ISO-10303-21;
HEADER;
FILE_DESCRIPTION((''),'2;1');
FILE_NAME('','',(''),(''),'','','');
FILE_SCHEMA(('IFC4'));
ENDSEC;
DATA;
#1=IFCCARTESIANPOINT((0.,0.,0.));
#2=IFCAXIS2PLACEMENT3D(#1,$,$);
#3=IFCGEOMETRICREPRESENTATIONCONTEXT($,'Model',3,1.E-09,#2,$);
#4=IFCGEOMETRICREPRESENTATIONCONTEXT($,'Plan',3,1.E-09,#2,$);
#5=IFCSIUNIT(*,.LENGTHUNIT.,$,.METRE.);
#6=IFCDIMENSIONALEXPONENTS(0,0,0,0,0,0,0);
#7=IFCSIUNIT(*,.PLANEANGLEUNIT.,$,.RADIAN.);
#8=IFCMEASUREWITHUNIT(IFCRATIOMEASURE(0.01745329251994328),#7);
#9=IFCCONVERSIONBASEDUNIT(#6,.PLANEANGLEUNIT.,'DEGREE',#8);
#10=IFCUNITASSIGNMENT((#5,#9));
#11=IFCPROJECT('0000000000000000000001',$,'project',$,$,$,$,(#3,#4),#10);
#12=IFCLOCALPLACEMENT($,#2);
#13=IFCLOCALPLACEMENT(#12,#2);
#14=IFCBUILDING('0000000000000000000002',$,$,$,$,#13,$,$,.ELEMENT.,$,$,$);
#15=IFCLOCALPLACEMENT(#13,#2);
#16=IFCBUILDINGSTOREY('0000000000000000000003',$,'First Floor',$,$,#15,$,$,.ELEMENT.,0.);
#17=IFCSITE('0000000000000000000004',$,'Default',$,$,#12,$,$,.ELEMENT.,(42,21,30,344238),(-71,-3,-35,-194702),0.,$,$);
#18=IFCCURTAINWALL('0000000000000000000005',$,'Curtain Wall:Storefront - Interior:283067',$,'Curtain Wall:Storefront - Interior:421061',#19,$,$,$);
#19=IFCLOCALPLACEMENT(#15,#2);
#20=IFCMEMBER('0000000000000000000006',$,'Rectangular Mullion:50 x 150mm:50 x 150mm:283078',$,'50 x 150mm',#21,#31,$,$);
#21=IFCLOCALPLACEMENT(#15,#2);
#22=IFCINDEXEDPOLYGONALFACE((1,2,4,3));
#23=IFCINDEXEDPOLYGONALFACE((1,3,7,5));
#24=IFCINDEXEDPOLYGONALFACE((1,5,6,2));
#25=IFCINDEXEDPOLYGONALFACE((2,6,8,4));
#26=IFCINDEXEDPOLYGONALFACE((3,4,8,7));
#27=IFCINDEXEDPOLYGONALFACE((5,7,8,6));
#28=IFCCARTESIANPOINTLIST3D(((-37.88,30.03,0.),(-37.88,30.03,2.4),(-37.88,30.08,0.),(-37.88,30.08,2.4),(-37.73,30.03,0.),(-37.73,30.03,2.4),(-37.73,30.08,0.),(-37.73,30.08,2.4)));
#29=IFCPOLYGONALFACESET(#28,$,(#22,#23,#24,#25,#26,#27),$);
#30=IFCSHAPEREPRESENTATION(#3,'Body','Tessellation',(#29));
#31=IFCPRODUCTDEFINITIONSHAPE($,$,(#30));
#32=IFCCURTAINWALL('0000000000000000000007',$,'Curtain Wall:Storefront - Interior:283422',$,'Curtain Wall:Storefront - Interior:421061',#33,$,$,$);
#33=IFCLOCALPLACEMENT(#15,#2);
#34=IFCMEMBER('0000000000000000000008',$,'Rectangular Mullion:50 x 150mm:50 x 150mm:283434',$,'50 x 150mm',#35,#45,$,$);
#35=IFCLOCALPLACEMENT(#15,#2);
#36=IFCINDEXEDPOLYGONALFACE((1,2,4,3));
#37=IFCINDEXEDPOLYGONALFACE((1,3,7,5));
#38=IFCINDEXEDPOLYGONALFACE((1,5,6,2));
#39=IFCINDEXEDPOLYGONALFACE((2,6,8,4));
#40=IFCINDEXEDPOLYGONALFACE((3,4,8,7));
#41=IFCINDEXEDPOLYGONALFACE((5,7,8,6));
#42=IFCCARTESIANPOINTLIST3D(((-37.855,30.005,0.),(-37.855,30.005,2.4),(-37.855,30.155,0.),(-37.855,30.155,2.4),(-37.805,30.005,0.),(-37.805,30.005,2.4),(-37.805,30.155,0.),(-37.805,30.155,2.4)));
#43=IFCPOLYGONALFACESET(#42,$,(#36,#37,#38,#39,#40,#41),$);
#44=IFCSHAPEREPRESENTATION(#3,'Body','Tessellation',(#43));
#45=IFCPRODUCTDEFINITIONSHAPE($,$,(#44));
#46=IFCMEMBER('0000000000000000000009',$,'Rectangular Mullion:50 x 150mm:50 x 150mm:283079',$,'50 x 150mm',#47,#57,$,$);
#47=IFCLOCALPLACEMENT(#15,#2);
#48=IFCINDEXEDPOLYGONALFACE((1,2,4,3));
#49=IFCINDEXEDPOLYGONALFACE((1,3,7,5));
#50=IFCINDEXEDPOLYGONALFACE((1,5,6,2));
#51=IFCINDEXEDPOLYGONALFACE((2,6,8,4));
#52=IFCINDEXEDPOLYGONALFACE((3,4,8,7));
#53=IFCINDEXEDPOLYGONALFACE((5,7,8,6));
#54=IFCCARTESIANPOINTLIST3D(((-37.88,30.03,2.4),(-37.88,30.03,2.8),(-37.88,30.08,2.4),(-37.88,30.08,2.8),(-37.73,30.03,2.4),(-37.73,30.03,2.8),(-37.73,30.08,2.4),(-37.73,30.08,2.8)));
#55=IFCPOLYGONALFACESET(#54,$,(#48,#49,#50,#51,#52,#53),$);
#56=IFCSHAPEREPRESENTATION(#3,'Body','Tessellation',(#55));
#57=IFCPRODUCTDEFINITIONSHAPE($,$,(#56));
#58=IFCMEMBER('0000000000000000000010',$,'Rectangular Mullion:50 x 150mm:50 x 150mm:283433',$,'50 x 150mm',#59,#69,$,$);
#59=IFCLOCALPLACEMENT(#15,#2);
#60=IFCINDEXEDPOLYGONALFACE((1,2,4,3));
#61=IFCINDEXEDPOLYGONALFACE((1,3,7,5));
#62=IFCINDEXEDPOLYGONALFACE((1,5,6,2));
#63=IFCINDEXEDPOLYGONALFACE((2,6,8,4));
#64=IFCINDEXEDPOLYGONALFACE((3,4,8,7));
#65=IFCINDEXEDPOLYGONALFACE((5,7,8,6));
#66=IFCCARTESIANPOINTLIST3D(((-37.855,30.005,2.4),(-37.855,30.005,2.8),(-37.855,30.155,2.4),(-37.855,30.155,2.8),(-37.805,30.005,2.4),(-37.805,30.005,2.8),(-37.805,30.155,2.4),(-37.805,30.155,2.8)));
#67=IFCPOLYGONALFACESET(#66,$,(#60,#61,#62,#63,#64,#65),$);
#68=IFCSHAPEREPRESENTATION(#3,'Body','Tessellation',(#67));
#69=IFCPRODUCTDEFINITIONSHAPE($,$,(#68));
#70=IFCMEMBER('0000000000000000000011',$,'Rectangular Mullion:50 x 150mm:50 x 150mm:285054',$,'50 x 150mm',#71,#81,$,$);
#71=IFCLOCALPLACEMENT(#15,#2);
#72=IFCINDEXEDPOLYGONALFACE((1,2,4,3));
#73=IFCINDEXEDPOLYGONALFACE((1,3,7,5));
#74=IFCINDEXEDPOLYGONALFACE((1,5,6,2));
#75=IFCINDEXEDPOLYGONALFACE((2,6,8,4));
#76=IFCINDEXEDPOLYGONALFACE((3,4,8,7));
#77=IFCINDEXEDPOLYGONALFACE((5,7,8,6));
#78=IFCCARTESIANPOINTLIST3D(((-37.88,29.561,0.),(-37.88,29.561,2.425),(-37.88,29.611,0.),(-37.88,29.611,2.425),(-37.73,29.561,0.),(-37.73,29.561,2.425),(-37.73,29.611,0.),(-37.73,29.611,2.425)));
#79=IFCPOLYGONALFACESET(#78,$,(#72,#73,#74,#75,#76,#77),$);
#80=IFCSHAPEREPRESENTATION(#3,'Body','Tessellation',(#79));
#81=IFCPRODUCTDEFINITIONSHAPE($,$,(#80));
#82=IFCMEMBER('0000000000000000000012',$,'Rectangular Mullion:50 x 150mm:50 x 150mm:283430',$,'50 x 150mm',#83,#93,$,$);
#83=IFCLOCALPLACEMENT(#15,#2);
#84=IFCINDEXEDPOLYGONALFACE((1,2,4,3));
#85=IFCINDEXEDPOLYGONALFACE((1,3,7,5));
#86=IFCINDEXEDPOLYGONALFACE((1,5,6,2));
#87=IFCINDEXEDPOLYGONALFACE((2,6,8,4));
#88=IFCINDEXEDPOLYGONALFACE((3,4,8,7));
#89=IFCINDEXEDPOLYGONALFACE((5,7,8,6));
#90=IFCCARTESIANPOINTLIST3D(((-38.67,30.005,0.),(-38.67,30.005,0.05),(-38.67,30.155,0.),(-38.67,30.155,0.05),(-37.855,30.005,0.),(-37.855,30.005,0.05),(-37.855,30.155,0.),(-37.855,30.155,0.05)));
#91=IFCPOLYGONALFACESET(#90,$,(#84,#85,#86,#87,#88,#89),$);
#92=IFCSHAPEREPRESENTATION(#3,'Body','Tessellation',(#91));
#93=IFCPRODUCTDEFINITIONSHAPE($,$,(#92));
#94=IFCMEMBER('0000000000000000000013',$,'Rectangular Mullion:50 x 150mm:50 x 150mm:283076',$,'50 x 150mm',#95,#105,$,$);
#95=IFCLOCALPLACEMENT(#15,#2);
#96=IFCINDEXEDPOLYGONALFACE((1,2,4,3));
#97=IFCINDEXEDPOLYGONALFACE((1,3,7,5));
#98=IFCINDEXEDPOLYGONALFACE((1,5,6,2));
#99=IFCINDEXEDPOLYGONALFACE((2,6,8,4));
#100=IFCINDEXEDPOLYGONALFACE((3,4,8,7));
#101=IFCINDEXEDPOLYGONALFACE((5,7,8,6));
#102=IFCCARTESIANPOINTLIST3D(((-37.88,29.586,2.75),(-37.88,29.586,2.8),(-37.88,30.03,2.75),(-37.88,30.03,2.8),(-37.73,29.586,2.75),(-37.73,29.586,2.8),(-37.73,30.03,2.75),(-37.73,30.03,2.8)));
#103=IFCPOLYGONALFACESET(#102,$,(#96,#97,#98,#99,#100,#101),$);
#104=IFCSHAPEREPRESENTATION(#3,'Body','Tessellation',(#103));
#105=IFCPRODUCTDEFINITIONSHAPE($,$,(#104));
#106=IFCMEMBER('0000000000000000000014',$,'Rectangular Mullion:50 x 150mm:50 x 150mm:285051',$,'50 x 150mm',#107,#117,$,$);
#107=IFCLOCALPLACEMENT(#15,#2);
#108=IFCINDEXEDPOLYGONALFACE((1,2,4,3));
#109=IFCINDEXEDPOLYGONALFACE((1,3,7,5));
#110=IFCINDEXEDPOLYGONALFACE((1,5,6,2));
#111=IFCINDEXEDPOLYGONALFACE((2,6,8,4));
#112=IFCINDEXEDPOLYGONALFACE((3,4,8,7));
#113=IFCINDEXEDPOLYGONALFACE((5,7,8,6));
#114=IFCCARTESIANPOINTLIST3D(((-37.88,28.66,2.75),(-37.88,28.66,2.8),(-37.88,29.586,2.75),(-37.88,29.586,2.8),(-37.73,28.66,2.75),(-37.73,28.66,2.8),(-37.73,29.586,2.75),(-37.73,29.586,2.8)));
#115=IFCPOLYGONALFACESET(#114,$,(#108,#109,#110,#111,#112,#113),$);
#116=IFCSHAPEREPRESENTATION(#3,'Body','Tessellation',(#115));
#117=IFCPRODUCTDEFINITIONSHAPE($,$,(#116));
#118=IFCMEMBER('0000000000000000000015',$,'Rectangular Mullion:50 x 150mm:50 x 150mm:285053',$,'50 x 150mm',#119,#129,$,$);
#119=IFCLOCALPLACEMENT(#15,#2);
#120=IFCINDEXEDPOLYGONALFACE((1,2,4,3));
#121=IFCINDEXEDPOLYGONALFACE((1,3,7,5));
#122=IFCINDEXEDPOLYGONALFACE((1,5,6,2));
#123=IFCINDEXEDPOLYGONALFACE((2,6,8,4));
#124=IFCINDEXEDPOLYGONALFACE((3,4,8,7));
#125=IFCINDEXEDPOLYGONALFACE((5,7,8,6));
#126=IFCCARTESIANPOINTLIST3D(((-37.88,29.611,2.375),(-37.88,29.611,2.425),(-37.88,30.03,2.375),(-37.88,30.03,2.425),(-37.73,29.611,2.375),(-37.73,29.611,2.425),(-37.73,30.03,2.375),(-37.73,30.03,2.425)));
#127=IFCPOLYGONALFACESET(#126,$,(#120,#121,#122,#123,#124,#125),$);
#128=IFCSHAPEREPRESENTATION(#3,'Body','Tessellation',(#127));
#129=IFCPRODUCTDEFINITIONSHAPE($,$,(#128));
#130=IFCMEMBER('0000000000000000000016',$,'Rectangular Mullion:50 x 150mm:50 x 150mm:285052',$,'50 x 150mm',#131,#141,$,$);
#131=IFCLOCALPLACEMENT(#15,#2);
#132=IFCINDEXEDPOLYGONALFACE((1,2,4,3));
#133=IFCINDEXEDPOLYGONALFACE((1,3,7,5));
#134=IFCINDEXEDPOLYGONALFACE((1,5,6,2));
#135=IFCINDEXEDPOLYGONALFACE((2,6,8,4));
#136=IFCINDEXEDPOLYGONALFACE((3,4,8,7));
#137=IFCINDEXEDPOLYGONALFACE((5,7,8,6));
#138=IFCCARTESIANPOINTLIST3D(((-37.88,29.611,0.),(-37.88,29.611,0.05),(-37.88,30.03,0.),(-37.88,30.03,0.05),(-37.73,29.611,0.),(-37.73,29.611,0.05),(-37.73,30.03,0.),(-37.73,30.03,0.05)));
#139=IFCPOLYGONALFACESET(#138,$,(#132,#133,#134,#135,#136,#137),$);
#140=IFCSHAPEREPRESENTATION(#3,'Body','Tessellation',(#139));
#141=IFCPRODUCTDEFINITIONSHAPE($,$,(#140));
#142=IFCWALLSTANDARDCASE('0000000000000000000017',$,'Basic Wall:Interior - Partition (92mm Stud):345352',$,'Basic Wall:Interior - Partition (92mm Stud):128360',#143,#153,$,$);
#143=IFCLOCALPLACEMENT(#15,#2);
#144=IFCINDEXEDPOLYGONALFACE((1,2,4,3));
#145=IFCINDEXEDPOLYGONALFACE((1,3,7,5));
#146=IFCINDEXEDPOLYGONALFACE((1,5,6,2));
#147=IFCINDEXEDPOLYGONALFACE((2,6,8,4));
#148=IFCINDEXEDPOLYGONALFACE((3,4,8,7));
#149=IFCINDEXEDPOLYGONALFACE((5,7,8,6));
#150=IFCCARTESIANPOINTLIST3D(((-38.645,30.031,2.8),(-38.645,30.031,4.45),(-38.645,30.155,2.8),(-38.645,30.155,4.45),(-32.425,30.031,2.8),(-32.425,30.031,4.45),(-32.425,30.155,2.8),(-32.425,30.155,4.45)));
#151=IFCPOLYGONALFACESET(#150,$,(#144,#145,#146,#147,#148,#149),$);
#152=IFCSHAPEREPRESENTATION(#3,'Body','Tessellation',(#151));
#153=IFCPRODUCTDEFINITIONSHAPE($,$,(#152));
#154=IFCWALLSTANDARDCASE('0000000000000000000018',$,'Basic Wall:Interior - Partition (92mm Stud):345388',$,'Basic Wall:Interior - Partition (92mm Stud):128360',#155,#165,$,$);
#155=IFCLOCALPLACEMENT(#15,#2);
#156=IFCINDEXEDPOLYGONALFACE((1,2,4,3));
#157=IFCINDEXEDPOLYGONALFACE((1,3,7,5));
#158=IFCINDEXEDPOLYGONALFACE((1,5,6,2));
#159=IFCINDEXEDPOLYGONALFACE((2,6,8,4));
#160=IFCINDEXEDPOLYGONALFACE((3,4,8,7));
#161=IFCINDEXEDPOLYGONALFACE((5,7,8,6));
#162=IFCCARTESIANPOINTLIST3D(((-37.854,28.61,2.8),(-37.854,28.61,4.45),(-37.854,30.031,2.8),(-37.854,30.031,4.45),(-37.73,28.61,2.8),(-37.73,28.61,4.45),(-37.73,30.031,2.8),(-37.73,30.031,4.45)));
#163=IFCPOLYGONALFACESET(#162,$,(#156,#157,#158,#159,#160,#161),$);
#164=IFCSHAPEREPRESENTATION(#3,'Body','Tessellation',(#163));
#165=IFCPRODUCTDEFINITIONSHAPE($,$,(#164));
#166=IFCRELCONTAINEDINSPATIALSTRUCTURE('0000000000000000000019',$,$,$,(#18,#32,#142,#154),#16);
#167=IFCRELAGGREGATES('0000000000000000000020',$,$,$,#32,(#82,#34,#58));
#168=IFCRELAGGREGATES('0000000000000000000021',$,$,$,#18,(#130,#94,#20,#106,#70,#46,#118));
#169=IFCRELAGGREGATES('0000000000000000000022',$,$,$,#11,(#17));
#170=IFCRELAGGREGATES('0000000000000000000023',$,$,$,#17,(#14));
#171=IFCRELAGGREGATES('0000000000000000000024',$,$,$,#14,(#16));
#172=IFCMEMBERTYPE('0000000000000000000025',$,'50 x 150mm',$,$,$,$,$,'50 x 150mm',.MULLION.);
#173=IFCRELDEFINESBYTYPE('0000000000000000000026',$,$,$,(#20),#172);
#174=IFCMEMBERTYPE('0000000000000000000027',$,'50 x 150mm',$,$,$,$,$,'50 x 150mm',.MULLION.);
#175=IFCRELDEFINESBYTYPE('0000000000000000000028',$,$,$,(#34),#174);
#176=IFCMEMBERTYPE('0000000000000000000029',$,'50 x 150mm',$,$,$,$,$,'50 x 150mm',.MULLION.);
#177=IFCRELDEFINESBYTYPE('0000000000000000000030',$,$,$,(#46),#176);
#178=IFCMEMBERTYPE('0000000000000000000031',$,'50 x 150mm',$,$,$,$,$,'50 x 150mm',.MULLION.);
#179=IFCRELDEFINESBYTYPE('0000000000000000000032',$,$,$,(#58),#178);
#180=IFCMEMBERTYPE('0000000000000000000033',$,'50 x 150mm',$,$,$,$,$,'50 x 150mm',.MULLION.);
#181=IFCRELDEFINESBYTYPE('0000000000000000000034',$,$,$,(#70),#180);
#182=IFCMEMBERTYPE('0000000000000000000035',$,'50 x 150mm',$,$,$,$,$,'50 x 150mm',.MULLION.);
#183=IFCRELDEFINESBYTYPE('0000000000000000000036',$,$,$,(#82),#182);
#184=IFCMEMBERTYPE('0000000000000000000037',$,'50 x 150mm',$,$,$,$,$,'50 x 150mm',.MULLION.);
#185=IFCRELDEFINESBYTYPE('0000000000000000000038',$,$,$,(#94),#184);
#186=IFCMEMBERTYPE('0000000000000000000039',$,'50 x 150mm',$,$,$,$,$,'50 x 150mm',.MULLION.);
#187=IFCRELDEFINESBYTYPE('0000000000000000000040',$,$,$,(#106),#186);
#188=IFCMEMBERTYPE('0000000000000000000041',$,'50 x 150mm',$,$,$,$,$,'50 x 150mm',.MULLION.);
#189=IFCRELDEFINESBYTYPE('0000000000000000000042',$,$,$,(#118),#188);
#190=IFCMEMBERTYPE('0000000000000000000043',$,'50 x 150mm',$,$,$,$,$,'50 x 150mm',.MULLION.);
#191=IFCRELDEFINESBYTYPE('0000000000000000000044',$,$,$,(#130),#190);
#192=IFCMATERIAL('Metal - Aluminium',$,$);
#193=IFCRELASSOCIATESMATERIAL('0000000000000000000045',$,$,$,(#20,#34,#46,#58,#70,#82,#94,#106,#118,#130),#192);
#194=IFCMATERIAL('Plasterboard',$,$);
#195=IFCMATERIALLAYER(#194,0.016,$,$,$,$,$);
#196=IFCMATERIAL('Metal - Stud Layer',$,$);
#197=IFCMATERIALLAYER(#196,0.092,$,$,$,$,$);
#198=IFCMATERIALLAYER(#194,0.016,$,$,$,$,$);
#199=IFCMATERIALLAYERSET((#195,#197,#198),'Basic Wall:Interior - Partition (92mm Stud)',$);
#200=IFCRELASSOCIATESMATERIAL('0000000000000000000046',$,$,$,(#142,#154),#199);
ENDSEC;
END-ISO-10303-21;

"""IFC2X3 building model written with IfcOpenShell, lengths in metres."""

from ifc_helpers import new_model, entity, si_unit, converted_unit, frame, frame_2d, origin, origin_2d_with_axis, place, context, project, spatial, rectangle, extrude, source, transform, mapped, material, layer, layer_set, layer_usage, type_object, type_shapes, element, aggregate, save


model = new_model("IFC2X3")

# Units and contexts
model_context = context("Model", 3, precision=1e-09, world=origin())
plan_context = context("Plan", 3, precision=1e-09, world=origin())
ifc_project = project(units=[si_unit("LENGTHUNIT", "METRE"), converted_unit("PLANEANGLEUNIT", "DEGREE", entity("IfcRatioMeasure", 0.01745329251994328), si_unit("PLANEANGLEUNIT", "RADIAN"), dimensions=[0, 0, 0, 0, 0, 0, 0])], contexts=[model_context, plan_context])

# Site, building, storey
site_placement = place(None, origin())
site = spatial("IfcSite", under=ifc_project, at=site_placement, Name="Default", CompositionType="ELEMENT", RefLatitude=(42, 21, 30, 344238), RefLongitude=(-71, -3, -35, -194702), RefElevation=0.0)
building_placement = place(site_placement, origin())
building = spatial("IfcBuilding", under=site, at=building_placement, CompositionType="ELEMENT")
storey_placement = place(building_placement, origin())
storey = spatial("IfcBuildingStorey", under=building, at=storey_placement, Name="First Floor", CompositionType="ELEMENT", Elevation=0.0)

# Curtain walls, members
curtain_wall_1_placement = place(storey_placement, origin())
curtain_wall_1 = element("IfcCurtainWall", 1, at=curtain_wall_1_placement, inside=storey, Name="Curtain Wall:Storefront - Interior:283067", ObjectType="Curtain Wall:Storefront - Interior:421061")
ifc_material_1 = material(Name="Metal - Aluminium")
member_type_1 = type_object("IfcMemberType", Name="50 x 150mm", ElementType="50 x 150mm", PredefinedType="MULLION")
shared_shape_1 = source(origin(), model_context, "Body", "SweptSolid", [
    extrude(rectangle(XDim=0.05, YDim=0.15, at=origin_2d_with_axis()), frame((-0.025, 0.0, -2.4), z_axis=(0.0, 0.0, 1.0), x_axis=(-1.0, 0.0, 0.0)), (0.0, 0.0, 1.0), 2.4),
])
type_shapes(member_type_1, [shared_shape_1])
member_1_placement = place(storey_placement, frame((-37.805, 30.08, 0.0), z_axis=(0.0, 0.0, -1.0), x_axis=(0.0, 1.0, 0.0)))
member_1 = element("IfcMember", 2, at=member_1_placement, type_object=member_type_1, material=ifc_material_1, Name="Rectangular Mullion:50 x 150mm:50 x 150mm:283078", ObjectType="50 x 150mm", context=model_context, shape_type="MappedRepresentation", body=[
    mapped(shared_shape_1, transform((0.0, 0.0, 0.0), scale=1.0)),
])
curtain_wall_2_placement = place(storey_placement, origin())
curtain_wall_2 = element("IfcCurtainWall", 3, at=curtain_wall_2_placement, inside=storey, Name="Curtain Wall:Storefront - Interior:283422", ObjectType="Curtain Wall:Storefront - Interior:421061")
member_type_2 = type_object("IfcMemberType", Name="50 x 150mm", ElementType="50 x 150mm", PredefinedType="MULLION")
type_shapes(member_type_2, [shared_shape_1])
member_2_placement = place(storey_placement, frame((-37.805, 30.08, 2.4)))
member_2 = element("IfcMember", 4, at=member_2_placement, type_object=member_type_2, material=ifc_material_1, Name="Rectangular Mullion:50 x 150mm:50 x 150mm:283434", ObjectType="50 x 150mm", context=model_context, shape_type="MappedRepresentation", body=[
    mapped(shared_shape_1, transform((0.0, 0.0, 0.0), scale=1.0)),
])

# Members
member_type_3 = type_object("IfcMemberType", Name="50 x 150mm", ElementType="50 x 150mm", PredefinedType="MULLION")
shared_shape_2 = source(origin(), model_context, "Body", "SweptSolid", [
    extrude(rectangle(XDim=0.05, YDim=0.15, at=origin_2d_with_axis()), frame((-0.025, 0.0, -0.4), z_axis=(0.0, 0.0, 1.0), x_axis=(-1.0, 0.0, 0.0)), (0.0, 0.0, 1.0), 0.4),
])
type_shapes(member_type_3, [shared_shape_2])
member_3_placement = place(storey_placement, frame((-37.805, 30.08, 2.4), z_axis=(0.0, 0.0, -1.0), x_axis=(0.0, 1.0, 0.0)))
member_3 = element("IfcMember", 5, at=member_3_placement, type_object=member_type_3, material=ifc_material_1, Name="Rectangular Mullion:50 x 150mm:50 x 150mm:283079", ObjectType="50 x 150mm", context=model_context, shape_type="MappedRepresentation", body=[
    mapped(shared_shape_2, transform((0.0, 0.0, 0.0), scale=1.0)),
])
member_type_4 = type_object("IfcMemberType", Name="50 x 150mm", ElementType="50 x 150mm", PredefinedType="MULLION")
type_shapes(member_type_4, [shared_shape_2])
member_4_placement = place(storey_placement, frame((-37.805, 30.08, 2.8)))
member_4 = element("IfcMember", 6, at=member_4_placement, type_object=member_type_4, material=ifc_material_1, Name="Rectangular Mullion:50 x 150mm:50 x 150mm:283433", ObjectType="50 x 150mm", context=model_context, shape_type="MappedRepresentation", body=[
    mapped(shared_shape_2, transform((0.0, 0.0, 0.0), scale=1.0)),
])
member_type_5 = type_object("IfcMemberType", Name="50 x 150mm", ElementType="50 x 150mm", PredefinedType="MULLION")
shared_shape_3 = source(origin(), model_context, "Body", "SweptSolid", [
    extrude(rectangle(XDim=0.05, YDim=0.15, at=origin_2d_with_axis()), frame((0.0, 0.0, -2.425), z_axis=(0.0, 0.0, 1.0), x_axis=(-1.0, 0.0, 0.0)), (0.0, 0.0, 1.0), 2.425),
])
type_shapes(member_type_5, [shared_shape_3])
member_5_placement = place(storey_placement, frame((-37.805, 29.586, 0.0), z_axis=(0.0, 0.0, -1.0), x_axis=(0.0, 1.0, 0.0)))
member_5 = element("IfcMember", 7, at=member_5_placement, type_object=member_type_5, material=ifc_material_1, Name="Rectangular Mullion:50 x 150mm:50 x 150mm:285054", ObjectType="50 x 150mm", context=model_context, shape_type="MappedRepresentation", body=[
    mapped(shared_shape_3, transform((0.0, 0.0, 0.0), scale=1.0)),
])
member_type_6 = type_object("IfcMemberType", Name="50 x 150mm", ElementType="50 x 150mm", PredefinedType="MULLION")
shared_shape_4 = source(origin(), model_context, "Body", "SweptSolid", [
    extrude(rectangle(XDim=0.05, YDim=0.15, at=origin_2d_with_axis()), frame((-0.025, 0.0, -0.815), z_axis=(0.0, 0.0, 1.0), x_axis=(-1.0, 0.0, 0.0)), (0.0, 0.0, 1.0), 0.815),
])
type_shapes(member_type_6, [shared_shape_4])
member_6_placement = place(storey_placement, frame((-37.855, 30.08, 0.0), z_axis=(1.0, 0.0, 0.0), x_axis=(0.0, 0.0, -1.0)))
member_6 = element("IfcMember", 8, at=member_6_placement, type_object=member_type_6, material=ifc_material_1, Name="Rectangular Mullion:50 x 150mm:50 x 150mm:283430", ObjectType="50 x 150mm", context=model_context, shape_type="MappedRepresentation", body=[
    mapped(shared_shape_4, transform((0.0, 0.0, 0.0), scale=1.0)),
])
member_type_7 = type_object("IfcMemberType", Name="50 x 150mm", ElementType="50 x 150mm", PredefinedType="MULLION")
shared_shape_5 = source(origin(), model_context, "Body", "SweptSolid", [
    extrude(rectangle(XDim=0.05, YDim=0.15, at=origin_2d_with_axis()), frame((-0.025, 0.0, -0.444), z_axis=(0.0, 0.0, 1.0), x_axis=(-1.0, 0.0, 0.0)), (0.0, 0.0, 1.0), 0.444),
])
type_shapes(member_type_7, [shared_shape_5])
member_7_placement = place(storey_placement, frame((-37.805, 30.03, 2.8), z_axis=(0.0, 1.0, 0.0), x_axis=(0.0, 0.0, 1.0)))
member_7 = element("IfcMember", 9, at=member_7_placement, type_object=member_type_7, material=ifc_material_1, Name="Rectangular Mullion:50 x 150mm:50 x 150mm:283076", ObjectType="50 x 150mm", context=model_context, shape_type="MappedRepresentation", body=[
    mapped(shared_shape_5, transform((0.0, 0.0, 0.0), scale=1.0)),
])
member_type_8 = type_object("IfcMemberType", Name="50 x 150mm", ElementType="50 x 150mm", PredefinedType="MULLION")
shared_shape_6 = source(origin(), model_context, "Body", "SweptSolid", [
    extrude(rectangle(XDim=0.05, YDim=0.15, at=origin_2d_with_axis()), frame((-0.025, 0.0, -0.926), z_axis=(0.0, 0.0, 1.0), x_axis=(-1.0, 0.0, 0.0)), (0.0, 0.0, 1.0), 0.926),
])
type_shapes(member_type_8, [shared_shape_6])
member_8_placement = place(storey_placement, frame((-37.805, 29.586, 2.8), z_axis=(0.0, 1.0, 0.0), x_axis=(0.0, 0.0, 1.0)))
member_8 = element("IfcMember", 10, at=member_8_placement, type_object=member_type_8, material=ifc_material_1, Name="Rectangular Mullion:50 x 150mm:50 x 150mm:285051", ObjectType="50 x 150mm", context=model_context, shape_type="MappedRepresentation", body=[
    mapped(shared_shape_6, transform((0.0, 0.0, 0.0), scale=1.0)),
])
member_type_9 = type_object("IfcMemberType", Name="50 x 150mm", ElementType="50 x 150mm", PredefinedType="MULLION")
shared_shape_7 = source(origin(), model_context, "Body", "SweptSolid", [
    extrude(rectangle(XDim=0.05, YDim=0.15, at=origin_2d_with_axis()), frame((0.0, 0.0, -0.419), z_axis=(0.0, 0.0, 1.0), x_axis=(-1.0, 0.0, 0.0)), (0.0, 0.0, 1.0), 0.419),
])
type_shapes(member_type_9, [shared_shape_7])
member_9_placement = place(storey_placement, frame((-37.805, 30.03, 2.4), z_axis=(0.0, 1.0, 0.0), x_axis=(0.0, 0.0, 1.0)))
member_9 = element("IfcMember", 11, at=member_9_placement, type_object=member_type_9, material=ifc_material_1, Name="Rectangular Mullion:50 x 150mm:50 x 150mm:285053", ObjectType="50 x 150mm", context=model_context, shape_type="MappedRepresentation", body=[
    mapped(shared_shape_7, transform((0.0, 0.0, 0.0), scale=1.0)),
])
member_type_10 = type_object("IfcMemberType", Name="50 x 150mm", ElementType="50 x 150mm", PredefinedType="MULLION")
shared_shape_8 = source(origin(), model_context, "Body", "SweptSolid", [
    extrude(rectangle(XDim=0.05, YDim=0.15, at=origin_2d_with_axis()), frame((-0.025, 0.0, -0.419), z_axis=(0.0, 0.0, 1.0), x_axis=(-1.0, 0.0, 0.0)), (0.0, 0.0, 1.0), 0.419),
])
type_shapes(member_type_10, [shared_shape_8])
member_10_placement = place(storey_placement, frame((-37.805, 29.611, 0.0), z_axis=(0.0, -1.0, 0.0), x_axis=(0.0, 0.0, -1.0)))
member_10 = element("IfcMember", 12, at=member_10_placement, type_object=member_type_10, material=ifc_material_1, Name="Rectangular Mullion:50 x 150mm:50 x 150mm:285052", ObjectType="50 x 150mm", context=model_context, shape_type="MappedRepresentation", body=[
    mapped(shared_shape_8, transform((0.0, 0.0, 0.0), scale=1.0)),
])

aggregate(curtain_wall_2, [member_6, member_2, member_4])
aggregate(curtain_wall_1, [member_10, member_7, member_1, member_8, member_5, member_3, member_9])

# Walls
ifc_material_2 = material(Name="Plasterboard")
ifc_layer_1 = layer(ifc_material_2, 0.016)
ifc_material_3 = material(Name="Metal - Stud Layer")
ifc_layer_2 = layer(ifc_material_3, 0.092)
ifc_layer_3 = layer(ifc_material_2, 0.016)
ifc_layer_set = layer_set([ifc_layer_1, ifc_layer_2, ifc_layer_3], Name="Basic Wall:Interior - Partition (92mm Stud)")
ifc_layer_usage = layer_usage(ifc_layer_set, "AXIS2", "NEGATIVE", 0.062)
wall_1_placement = place(storey_placement, frame((-38.645, 30.093, 2.8)))
element("IfcWallStandardCase", 13, at=wall_1_placement, inside=storey, material=ifc_layer_usage, Name="Basic Wall:Interior - Partition (92mm Stud):345352", ObjectType="Basic Wall:Interior - Partition (92mm Stud):128360", context=model_context, shape_type="SweptSolid", body=[
    extrude(rectangle(XDim=6.22, YDim=0.124, at=frame_2d((3.11, 0.0), x_axis=(-1.0, 0.0))), origin(), (0.0, 0.0, 1.0), 1.65),
])
wall_2_placement = place(storey_placement, frame((-37.792, 30.031, 2.8), z_axis=(0.0, 0.0, 1.0), x_axis=(0.0, -1.0, 0.0)))
element("IfcWallStandardCase", 14, at=wall_2_placement, inside=storey, material=ifc_layer_usage, Name="Basic Wall:Interior - Partition (92mm Stud):345388", ObjectType="Basic Wall:Interior - Partition (92mm Stud):128360", context=model_context, shape_type="SweptSolid", body=[
    extrude(rectangle(XDim=1.421, YDim=0.124, at=frame_2d((0.7105, 0.0), x_axis=(-1.0, 0.0))), origin(), (0.0, 0.0, 1.0), 1.65),
])

save(model, "model.ifc")
